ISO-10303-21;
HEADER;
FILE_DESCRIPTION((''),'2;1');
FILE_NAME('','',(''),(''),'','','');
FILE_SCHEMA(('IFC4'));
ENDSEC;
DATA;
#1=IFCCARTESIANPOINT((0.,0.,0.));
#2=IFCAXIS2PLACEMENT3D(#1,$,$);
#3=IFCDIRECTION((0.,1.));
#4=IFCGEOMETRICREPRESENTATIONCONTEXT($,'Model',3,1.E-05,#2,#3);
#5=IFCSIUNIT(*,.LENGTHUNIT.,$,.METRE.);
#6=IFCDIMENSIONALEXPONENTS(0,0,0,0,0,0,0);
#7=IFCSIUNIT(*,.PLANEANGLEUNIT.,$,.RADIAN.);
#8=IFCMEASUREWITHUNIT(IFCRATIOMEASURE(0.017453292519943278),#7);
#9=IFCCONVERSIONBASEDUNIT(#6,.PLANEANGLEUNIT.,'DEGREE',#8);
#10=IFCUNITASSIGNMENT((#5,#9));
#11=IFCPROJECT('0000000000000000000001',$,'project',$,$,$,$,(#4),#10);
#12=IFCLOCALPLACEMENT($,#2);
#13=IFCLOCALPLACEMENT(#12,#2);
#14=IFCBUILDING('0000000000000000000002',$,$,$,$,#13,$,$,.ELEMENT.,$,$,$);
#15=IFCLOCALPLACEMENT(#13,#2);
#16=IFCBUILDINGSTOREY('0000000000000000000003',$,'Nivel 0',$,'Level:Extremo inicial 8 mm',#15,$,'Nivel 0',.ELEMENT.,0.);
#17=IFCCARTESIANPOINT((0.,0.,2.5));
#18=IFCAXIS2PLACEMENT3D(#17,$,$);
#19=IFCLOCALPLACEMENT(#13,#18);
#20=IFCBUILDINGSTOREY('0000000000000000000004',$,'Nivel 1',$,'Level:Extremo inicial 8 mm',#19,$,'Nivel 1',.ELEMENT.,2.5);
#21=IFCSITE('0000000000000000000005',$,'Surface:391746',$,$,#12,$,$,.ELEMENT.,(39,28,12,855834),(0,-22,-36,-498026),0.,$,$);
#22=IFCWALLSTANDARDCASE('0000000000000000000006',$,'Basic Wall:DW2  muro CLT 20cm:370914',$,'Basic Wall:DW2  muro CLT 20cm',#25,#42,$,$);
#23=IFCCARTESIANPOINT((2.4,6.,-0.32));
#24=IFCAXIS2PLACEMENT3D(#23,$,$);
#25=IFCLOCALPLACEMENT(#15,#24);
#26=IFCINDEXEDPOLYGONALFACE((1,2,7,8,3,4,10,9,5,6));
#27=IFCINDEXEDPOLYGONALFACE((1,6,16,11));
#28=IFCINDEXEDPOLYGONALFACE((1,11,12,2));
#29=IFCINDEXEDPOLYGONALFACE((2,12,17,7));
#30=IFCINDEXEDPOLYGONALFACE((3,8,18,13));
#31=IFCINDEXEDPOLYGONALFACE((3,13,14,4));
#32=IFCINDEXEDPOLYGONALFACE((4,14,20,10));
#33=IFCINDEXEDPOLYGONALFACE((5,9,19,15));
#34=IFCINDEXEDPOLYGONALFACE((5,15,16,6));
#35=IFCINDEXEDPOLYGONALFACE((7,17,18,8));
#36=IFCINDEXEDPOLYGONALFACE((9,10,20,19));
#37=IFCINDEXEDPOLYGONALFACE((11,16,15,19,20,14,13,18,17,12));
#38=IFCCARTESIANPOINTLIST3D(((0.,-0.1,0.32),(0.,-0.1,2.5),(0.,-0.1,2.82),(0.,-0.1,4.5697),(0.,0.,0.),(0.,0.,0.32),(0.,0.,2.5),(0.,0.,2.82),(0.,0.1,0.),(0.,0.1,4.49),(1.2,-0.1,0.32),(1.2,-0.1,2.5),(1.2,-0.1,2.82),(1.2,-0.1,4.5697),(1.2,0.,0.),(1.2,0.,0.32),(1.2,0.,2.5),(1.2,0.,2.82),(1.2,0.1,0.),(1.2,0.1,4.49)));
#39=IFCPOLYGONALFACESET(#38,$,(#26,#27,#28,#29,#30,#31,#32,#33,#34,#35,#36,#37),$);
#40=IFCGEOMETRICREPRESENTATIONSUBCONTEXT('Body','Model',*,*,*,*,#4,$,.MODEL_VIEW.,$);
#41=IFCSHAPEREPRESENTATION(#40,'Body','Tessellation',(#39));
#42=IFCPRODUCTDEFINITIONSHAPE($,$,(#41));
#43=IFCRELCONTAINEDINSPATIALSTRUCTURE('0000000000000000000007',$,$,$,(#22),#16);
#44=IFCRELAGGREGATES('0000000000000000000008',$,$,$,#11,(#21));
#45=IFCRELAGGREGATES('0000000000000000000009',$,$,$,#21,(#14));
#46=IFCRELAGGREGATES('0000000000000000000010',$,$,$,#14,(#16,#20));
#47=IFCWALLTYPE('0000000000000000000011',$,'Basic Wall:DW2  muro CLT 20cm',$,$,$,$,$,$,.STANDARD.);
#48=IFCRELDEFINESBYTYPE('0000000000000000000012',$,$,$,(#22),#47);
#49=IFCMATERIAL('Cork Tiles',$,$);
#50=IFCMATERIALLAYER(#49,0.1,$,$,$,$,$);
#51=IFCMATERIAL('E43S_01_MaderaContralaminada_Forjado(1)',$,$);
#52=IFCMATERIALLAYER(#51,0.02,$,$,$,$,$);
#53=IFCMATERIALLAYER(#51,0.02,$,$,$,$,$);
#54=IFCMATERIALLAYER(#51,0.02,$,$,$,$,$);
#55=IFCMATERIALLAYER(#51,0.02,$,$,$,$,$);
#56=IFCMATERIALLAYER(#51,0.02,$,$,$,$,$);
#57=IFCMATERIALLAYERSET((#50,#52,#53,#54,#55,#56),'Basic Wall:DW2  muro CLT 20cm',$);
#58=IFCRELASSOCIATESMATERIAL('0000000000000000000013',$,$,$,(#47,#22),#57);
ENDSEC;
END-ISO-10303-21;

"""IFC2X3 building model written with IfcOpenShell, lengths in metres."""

from ifc_helpers import new_model, entity, si_unit, converted_unit, direction, frame, frame_2d, origin, place, context, subcontext, project, spatial, polyline, rectangle, extrude, clip, bounded_halfspace, material, layer, layer_set, layer_usage, type_object, element, save


model = new_model("IFC2X3")

# Units and contexts
model_context = context("Model", 3, precision=1e-05, world=origin(), true_north=direction((0.0, 1.0)))
body_context = subcontext(model_context, "Body", "Model", "MODEL_VIEW")
ifc_project = project(units=[si_unit("LENGTHUNIT", "METRE"), converted_unit("PLANEANGLEUNIT", "DEGREE", entity("IfcRatioMeasure", 0.017453292519943278), si_unit("PLANEANGLEUNIT", "RADIAN"), dimensions=[0, 0, 0, 0, 0, 0, 0])], contexts=[model_context])

# Site, building, storey
site_placement = place(None, origin())
site = spatial("IfcSite", under=ifc_project, at=site_placement, Name="Surface:391746", CompositionType="ELEMENT", RefLatitude=(39, 28, 12, 855834), RefLongitude=(0, -22, -36, -498026), RefElevation=0.0)
building_placement = place(site_placement, origin())
building = spatial("IfcBuilding", under=site, at=building_placement, CompositionType="ELEMENT")
storey_1_placement = place(building_placement, origin())
storey_1 = spatial("IfcBuildingStorey", under=building, at=storey_1_placement, Name="Nivel 0", ObjectType="Level:Extremo inicial 8 mm", LongName="Nivel 0", CompositionType="ELEMENT", Elevation=0.0)

# Shared definitions
ifc_material_1 = material(Name="E43S_01_MaderaContralaminada_Forjado(1)")

# Shared definitions
ifc_material_2 = material(Name="Cork Tiles")

# Shared definitions
ifc_layer_1 = layer(ifc_material_2, 0.1)
ifc_layer_2 = layer(ifc_material_1, 0.02)
ifc_layer_3 = layer(ifc_material_1, 0.02)
ifc_layer_4 = layer(ifc_material_1, 0.02)
ifc_layer_5 = layer(ifc_material_1, 0.02)
ifc_layer_6 = layer(ifc_material_1, 0.02)
ifc_layer_set_1 = layer_set([ifc_layer_1, ifc_layer_2, ifc_layer_3, ifc_layer_4, ifc_layer_5, ifc_layer_6], Name="Basic Wall:DW2  muro CLT 20cm")
wall_type_1 = type_object("IfcWallType", Name="Basic Wall:DW2  muro CLT 20cm", PredefinedType="STANDARD", material=ifc_layer_set_1)

# Shared definitions
storey_2_placement = place(building_placement, frame((0.0, 0.0, 2.5)))
storey_2 = spatial("IfcBuildingStorey", under=building, at=storey_2_placement, Name="Nivel 1", ObjectType="Level:Extremo inicial 8 mm", LongName="Nivel 1", CompositionType="ELEMENT", Elevation=2.5)

# Wall, openings
ifc_layer_usage_1 = layer_usage(ifc_layer_set_1, "AXIS2", "NEGATIVE", 0.1)
wall_1_placement = place(storey_1_placement, frame((2.4, 6.0, -0.32)))
wall_1 = element("IfcWallStandardCase", 1, at=wall_1_placement, inside=storey_1, type_object=wall_type_1, material=ifc_layer_usage_1, Name="Basic Wall:DW2  muro CLT 20cm:370914", ObjectType="Basic Wall:DW2  muro CLT 20cm", context=body_context, shape_type="Clipping", body=[
    clip(clip(extrude(rectangle(XDim=1.2, YDim=0.2, at=frame_2d((0.6, 0.0), x_axis=(-1.0, 0.0))), origin(), (0.0, 0.0, 1.0), 4.5697), bounded_halfspace(frame((0.0, -0.1, 4.5697), z_axis=(0.0, 0.370288, 0.928917), x_axis=(-1.0, 0.0, 0.0)), False, frame((0.0, -0.1, 4.5697)), polyline([(0.0, 0.0), (1.2, 0.0), (1.2, 0.2), (0.0, 0.2), (0.0, 0.0)]))), bounded_halfspace(frame((1.2, -0.1, 0.32), z_axis=(0.0, 0.0, -1.0), x_axis=(0.0, 1.0, 0.0)), False, frame((1.2, -0.1, 0.32)), polyline([(0.0, 0.0), (0.0, 0.1), (-1.2, 0.1), (-1.2, 0.0), (0.0, 0.0)]))),
])
opening_1_placement = place(wall_1_placement, origin())
element("IfcOpeningElement", 2, at=opening_1_placement, cuts=wall_1, ObjectType="Opening", context=body_context, shape_type="SweptSolid", body=[
    extrude(rectangle(XDim=2.1, YDim=0.8, at=frame_2d((0.0, 0.0), x_axis=(1.0, 0.0))), frame((-1.5, -1.424, 1.37), z_axis=(0.0, 1.0, 0.0), x_axis=(0.0, 0.0, -1.0)), (0.0, 0.0, 1.0), 3.048),
])
opening_2_placement = place(wall_1_placement, origin())
element("IfcOpeningElement", 3, at=opening_2_placement, cuts=wall_1, ObjectType="Opening", context=body_context, shape_type="SweptSolid", body=[
    extrude(rectangle(XDim=1.53, YDim=0.9, at=frame_2d((0.0, 0.0), x_axis=(1.0, 0.0))), frame((2.85, -1.378, 3.585), z_axis=(0.0, 1.0, 0.0), x_axis=(0.0, 0.0, -1.0)), (0.0, 0.0, 1.0), 3.048),
])
opening_3_placement = place(wall_1_placement, origin())
element("IfcOpeningElement", 4, at=opening_3_placement, cuts=wall_1, ObjectType="Recess", context=body_context, shape_type="SweptSolid", body=[
    extrude(rectangle(XDim=0.32, YDim=1.1, at=frame_2d((0.0, 0.0), x_axis=(0.0, 1.0))), frame((-1.75, -0.1, 2.66), z_axis=(0.0, 1.0, 0.0), x_axis=(1.0, 0.0, 0.0)), (0.0, 0.0, 1.0), 0.1),
    extrude(rectangle(XDim=0.32, YDim=1.2, at=frame_2d((0.0, 0.0), x_axis=(0.0, 1.0))), frame((-0.6, -0.1, 2.66), z_axis=(0.0, 1.0, 0.0), x_axis=(1.0, 0.0, 0.0)), (0.0, 0.0, 1.0), 0.1),
    extrude(rectangle(XDim=0.32, YDim=1.2, at=frame_2d((0.0, 0.0), x_axis=(0.0, 1.0))), frame((0.6, -0.1, 2.66), z_axis=(0.0, 1.0, 0.0), x_axis=(1.0, 0.0, 0.0)), (0.0, 0.0, 1.0), 0.1),
])

save(model, "model.ifc")
